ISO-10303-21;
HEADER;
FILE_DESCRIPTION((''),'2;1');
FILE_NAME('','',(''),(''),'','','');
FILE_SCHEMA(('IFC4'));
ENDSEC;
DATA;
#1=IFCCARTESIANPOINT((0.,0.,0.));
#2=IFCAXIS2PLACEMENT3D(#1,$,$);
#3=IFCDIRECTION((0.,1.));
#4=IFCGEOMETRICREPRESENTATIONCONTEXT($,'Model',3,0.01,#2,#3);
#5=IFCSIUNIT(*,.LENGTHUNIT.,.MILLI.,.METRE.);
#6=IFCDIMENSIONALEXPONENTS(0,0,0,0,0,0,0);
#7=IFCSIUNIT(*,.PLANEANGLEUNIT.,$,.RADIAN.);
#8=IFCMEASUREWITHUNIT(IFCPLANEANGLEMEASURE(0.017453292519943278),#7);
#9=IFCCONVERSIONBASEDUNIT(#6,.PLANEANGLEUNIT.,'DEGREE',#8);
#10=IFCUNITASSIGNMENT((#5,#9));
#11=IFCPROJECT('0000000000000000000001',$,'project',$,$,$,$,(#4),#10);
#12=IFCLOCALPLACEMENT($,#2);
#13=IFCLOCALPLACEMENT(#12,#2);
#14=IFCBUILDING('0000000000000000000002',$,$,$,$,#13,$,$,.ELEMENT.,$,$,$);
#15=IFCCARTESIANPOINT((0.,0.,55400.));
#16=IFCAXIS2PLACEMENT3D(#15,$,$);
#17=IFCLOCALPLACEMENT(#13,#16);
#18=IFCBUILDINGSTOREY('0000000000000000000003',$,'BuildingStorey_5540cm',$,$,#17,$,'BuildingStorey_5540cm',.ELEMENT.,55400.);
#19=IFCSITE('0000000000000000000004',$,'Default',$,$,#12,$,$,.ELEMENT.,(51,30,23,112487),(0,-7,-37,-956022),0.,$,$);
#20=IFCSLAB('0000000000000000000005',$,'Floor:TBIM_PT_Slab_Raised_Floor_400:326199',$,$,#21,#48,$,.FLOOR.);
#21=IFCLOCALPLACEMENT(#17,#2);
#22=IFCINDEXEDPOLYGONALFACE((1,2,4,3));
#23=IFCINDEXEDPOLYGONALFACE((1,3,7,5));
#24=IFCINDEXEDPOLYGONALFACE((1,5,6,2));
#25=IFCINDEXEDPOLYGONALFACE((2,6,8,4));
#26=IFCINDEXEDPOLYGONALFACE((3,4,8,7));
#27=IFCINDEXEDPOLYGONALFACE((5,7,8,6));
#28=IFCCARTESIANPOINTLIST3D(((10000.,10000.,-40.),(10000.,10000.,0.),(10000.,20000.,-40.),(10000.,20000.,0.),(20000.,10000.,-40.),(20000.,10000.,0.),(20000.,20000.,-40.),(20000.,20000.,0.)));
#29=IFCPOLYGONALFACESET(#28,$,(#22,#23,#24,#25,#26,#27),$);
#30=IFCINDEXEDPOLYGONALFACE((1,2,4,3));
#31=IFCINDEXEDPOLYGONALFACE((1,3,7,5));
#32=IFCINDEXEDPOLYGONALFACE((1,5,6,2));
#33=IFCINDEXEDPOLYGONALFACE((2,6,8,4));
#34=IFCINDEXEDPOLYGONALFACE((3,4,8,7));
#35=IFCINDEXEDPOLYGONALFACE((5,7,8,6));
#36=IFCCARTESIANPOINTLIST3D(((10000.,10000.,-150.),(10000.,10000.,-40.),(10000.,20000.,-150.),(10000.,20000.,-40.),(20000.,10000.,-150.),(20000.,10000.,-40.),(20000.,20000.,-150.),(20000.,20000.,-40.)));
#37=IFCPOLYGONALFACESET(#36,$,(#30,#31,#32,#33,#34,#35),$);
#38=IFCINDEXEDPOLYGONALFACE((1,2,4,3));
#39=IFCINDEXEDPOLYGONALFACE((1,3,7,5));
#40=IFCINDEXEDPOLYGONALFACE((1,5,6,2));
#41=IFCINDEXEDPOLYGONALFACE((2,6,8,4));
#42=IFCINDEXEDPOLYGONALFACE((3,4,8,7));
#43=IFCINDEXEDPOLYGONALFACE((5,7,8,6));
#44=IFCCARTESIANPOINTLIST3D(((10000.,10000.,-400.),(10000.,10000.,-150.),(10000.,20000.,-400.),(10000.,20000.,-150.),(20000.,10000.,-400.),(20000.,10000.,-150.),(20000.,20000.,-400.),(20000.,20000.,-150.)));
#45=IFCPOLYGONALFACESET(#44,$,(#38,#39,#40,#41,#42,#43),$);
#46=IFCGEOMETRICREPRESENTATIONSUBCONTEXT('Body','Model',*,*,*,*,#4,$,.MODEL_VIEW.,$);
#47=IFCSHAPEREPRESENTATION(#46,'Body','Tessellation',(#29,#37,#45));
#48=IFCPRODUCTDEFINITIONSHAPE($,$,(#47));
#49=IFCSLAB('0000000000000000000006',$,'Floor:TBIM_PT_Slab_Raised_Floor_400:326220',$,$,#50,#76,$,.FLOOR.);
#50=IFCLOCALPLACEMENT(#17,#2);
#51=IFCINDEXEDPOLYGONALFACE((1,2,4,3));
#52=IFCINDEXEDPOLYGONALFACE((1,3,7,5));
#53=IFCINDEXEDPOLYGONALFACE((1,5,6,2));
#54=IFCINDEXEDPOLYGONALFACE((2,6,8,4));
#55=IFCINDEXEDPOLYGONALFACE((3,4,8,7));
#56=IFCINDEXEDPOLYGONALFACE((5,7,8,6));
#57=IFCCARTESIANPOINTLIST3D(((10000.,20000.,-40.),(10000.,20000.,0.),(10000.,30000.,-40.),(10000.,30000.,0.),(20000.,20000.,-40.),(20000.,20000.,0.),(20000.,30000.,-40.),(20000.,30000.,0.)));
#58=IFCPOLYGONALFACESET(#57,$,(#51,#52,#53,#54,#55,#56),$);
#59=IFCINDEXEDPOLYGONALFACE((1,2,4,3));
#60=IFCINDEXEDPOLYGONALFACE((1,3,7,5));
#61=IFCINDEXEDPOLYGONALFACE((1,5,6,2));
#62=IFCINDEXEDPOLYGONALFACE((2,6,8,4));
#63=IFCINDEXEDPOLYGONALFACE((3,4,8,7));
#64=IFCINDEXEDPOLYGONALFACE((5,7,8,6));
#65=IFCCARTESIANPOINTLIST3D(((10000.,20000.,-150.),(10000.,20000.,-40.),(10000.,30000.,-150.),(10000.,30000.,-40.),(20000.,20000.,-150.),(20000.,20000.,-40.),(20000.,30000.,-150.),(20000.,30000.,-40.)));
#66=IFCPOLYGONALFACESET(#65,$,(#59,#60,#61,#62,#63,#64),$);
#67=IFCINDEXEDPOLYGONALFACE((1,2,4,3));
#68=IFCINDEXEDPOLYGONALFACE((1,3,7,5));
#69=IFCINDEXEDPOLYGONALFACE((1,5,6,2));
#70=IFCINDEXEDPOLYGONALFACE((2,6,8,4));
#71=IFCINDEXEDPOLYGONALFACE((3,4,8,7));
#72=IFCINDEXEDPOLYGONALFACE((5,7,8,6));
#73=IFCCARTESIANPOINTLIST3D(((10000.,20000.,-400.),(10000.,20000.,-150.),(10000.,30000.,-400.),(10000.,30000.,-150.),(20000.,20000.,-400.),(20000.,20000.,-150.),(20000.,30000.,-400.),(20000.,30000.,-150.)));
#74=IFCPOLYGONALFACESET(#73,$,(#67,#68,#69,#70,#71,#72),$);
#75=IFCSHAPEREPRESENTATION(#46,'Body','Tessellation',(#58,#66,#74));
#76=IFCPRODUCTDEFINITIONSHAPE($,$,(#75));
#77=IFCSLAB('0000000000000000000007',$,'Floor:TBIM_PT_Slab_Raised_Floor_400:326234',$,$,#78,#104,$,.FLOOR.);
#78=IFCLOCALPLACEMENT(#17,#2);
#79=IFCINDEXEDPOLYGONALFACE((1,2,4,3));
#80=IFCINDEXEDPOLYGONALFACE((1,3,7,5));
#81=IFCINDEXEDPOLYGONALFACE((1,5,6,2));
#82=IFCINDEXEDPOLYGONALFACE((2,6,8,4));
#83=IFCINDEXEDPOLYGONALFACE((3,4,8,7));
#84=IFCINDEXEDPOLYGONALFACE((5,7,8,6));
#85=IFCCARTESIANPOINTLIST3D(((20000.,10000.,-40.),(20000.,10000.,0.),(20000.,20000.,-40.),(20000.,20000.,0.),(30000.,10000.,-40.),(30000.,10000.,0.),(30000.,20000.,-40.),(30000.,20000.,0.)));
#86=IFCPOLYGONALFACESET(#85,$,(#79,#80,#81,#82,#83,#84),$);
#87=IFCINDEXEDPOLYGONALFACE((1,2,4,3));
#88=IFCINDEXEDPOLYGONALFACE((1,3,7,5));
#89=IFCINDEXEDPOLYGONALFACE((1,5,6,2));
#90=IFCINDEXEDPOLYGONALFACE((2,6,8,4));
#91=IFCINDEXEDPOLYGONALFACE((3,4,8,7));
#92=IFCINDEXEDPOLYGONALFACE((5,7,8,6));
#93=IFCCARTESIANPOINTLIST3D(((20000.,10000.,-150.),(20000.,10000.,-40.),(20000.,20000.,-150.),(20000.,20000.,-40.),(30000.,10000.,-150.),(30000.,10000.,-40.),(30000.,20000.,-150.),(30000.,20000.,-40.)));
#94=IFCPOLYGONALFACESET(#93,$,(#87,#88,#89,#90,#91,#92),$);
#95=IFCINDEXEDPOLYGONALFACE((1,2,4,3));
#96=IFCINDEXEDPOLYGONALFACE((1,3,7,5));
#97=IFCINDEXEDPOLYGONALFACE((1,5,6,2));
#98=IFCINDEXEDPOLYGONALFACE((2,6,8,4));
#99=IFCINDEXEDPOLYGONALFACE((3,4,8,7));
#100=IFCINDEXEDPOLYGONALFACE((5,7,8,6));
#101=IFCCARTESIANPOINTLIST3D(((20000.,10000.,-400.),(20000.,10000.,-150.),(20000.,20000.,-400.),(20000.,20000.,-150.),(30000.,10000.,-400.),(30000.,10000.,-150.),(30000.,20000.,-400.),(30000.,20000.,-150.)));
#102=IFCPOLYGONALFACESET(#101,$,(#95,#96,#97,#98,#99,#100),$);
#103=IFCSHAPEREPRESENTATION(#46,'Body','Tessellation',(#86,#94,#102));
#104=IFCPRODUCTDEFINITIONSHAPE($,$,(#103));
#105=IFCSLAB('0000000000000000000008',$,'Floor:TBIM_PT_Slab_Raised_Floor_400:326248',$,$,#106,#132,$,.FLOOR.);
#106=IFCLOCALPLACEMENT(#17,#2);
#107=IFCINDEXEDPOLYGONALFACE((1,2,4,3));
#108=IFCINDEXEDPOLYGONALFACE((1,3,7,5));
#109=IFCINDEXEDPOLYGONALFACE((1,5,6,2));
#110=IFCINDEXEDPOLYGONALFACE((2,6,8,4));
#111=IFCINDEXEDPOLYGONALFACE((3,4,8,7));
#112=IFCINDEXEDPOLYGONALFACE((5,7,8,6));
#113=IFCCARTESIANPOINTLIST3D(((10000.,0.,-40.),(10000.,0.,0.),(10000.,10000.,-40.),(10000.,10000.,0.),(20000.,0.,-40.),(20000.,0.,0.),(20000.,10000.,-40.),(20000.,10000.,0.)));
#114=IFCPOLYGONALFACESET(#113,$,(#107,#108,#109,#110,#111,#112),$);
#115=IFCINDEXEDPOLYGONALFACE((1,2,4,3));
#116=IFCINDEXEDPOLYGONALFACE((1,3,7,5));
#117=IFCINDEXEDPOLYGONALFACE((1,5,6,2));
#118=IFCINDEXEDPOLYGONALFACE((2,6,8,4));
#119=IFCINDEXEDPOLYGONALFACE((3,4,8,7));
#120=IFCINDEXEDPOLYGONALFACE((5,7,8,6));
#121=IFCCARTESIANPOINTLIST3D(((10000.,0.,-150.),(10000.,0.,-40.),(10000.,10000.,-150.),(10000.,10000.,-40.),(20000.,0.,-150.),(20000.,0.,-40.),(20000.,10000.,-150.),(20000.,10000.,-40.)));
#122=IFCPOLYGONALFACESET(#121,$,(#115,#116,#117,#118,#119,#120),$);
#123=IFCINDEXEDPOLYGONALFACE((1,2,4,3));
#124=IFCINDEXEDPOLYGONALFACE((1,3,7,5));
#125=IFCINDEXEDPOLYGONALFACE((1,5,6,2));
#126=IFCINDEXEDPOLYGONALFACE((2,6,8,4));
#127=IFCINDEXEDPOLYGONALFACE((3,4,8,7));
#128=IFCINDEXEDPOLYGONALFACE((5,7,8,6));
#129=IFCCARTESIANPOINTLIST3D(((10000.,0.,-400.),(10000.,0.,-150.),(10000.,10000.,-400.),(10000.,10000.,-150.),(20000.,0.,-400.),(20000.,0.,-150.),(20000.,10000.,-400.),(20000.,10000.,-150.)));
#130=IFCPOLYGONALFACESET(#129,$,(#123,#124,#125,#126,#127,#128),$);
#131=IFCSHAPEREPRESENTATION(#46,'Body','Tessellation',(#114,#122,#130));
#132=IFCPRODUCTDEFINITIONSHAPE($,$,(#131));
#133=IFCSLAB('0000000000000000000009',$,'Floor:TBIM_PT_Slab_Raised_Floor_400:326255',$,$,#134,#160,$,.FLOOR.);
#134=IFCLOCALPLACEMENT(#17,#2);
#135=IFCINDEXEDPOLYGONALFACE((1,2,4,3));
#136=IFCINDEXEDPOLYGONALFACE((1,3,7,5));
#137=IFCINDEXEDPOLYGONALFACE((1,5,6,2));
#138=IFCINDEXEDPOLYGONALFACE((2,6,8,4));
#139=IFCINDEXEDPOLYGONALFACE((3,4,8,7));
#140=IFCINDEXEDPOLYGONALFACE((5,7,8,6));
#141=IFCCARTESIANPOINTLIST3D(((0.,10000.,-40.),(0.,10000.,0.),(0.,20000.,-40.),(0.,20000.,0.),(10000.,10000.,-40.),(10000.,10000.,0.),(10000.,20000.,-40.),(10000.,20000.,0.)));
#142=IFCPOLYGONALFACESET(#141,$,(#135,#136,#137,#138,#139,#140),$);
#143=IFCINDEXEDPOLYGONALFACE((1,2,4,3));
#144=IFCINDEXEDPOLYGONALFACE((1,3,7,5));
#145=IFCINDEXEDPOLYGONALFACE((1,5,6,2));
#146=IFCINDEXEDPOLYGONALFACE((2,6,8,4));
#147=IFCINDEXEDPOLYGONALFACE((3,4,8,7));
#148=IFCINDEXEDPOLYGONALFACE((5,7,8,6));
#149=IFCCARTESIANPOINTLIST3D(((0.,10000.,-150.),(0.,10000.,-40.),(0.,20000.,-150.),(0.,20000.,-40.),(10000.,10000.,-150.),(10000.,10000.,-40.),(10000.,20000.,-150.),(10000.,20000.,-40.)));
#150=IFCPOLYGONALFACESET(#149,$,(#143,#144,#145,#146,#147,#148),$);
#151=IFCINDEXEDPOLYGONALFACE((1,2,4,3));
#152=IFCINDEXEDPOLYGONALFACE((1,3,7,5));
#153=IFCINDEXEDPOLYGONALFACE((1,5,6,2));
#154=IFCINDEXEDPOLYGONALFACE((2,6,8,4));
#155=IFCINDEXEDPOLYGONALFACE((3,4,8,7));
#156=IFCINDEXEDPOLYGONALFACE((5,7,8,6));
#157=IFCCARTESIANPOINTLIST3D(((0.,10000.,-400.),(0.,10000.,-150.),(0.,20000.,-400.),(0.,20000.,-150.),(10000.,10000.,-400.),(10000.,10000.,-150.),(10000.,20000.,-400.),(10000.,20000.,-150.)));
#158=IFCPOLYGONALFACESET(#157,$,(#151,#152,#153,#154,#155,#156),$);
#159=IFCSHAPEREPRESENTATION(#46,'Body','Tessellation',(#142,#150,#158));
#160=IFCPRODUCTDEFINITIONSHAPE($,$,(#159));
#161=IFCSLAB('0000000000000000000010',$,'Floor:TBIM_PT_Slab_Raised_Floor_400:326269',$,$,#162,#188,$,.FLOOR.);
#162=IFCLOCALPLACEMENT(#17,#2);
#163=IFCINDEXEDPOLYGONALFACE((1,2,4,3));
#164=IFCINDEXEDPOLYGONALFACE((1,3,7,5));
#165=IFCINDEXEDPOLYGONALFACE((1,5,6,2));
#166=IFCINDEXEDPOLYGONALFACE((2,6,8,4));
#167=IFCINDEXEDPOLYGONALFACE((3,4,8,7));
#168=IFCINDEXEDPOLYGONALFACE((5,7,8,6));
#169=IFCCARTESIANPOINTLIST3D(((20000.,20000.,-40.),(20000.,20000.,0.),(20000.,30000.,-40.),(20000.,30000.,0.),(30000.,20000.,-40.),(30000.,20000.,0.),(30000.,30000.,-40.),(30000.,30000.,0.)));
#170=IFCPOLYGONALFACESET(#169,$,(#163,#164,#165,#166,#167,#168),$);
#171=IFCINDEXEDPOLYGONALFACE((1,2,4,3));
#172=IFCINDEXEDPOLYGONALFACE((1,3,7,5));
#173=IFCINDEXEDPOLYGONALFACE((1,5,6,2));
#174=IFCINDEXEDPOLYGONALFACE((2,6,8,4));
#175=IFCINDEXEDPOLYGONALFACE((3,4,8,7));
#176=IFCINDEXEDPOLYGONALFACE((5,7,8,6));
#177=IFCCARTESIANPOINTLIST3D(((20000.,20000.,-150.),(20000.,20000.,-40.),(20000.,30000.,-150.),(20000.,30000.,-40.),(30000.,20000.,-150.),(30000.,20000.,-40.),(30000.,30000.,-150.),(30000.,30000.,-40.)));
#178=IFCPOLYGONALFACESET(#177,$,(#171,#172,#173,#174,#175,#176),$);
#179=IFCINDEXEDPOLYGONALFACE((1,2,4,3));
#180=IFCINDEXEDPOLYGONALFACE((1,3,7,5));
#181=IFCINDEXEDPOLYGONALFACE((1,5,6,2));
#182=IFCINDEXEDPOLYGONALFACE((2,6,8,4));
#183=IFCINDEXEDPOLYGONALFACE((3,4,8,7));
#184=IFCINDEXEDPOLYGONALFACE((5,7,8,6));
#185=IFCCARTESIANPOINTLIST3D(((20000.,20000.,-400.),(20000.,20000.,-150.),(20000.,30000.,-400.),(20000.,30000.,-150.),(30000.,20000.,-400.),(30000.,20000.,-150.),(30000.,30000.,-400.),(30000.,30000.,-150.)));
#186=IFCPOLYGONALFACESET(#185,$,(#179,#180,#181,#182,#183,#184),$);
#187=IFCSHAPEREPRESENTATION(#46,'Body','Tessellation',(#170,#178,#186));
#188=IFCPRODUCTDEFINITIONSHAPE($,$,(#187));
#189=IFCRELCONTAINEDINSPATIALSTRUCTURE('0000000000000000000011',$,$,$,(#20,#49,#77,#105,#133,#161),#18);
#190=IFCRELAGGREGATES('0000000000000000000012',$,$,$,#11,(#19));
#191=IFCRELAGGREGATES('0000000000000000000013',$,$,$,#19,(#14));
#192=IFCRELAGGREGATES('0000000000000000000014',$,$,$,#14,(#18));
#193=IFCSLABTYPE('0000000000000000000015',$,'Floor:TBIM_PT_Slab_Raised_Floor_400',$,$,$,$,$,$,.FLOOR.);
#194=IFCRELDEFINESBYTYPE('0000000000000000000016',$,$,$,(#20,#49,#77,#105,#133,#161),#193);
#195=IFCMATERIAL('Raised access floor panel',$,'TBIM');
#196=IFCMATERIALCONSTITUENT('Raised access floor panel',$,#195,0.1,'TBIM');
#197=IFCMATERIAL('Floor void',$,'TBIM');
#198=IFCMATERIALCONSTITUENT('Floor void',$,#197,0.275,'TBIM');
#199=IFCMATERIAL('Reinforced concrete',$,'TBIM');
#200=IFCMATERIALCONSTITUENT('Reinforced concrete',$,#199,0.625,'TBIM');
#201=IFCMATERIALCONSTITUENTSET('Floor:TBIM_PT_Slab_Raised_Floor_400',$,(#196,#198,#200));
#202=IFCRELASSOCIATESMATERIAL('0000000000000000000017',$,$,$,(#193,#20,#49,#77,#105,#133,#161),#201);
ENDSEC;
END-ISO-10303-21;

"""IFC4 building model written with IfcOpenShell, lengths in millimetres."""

from ifc_helpers import new_model, entity, si_unit, converted_unit, direction, frame, origin, place, context, subcontext, project, spatial, indexed_curve, outline, extrude, material, constituent, constituent_set, type_object, element, save


model = new_model("IFC4")

# Units and contexts
model_context = context("Model", 3, precision=0.01, world=origin(), true_north=direction((0.0, 1.0)))
body_context = subcontext(model_context, "Body", "Model", "MODEL_VIEW")
ifc_project = project(units=[si_unit("LENGTHUNIT", "METRE", prefix="MILLI"), converted_unit("PLANEANGLEUNIT", "DEGREE", entity("IfcPlaneAngleMeasure", 0.017453292519943278), si_unit("PLANEANGLEUNIT", "RADIAN"), dimensions=[0, 0, 0, 0, 0, 0, 0])], contexts=[model_context])

# Site, building, storey
site_placement = place(None, origin())
site = spatial("IfcSite", under=ifc_project, at=site_placement, Name="Default", CompositionType="ELEMENT", RefLatitude=(51, 30, 23, 112487), RefLongitude=(0, -7, -37, -956022), RefElevation=0.0)
building_placement = place(site_placement, origin())
building = spatial("IfcBuilding", under=site, at=building_placement, CompositionType="ELEMENT")
storey_placement = place(building_placement, frame((0.0, 0.0, 55400.0)))
storey = spatial("IfcBuildingStorey", under=building, at=storey_placement, Name="BuildingStorey_5540cm", LongName="BuildingStorey_5540cm", CompositionType="ELEMENT", Elevation=55400.0)

# Slabs
ifc_material_1 = material(Name="Raised access floor panel", Category="TBIM")
ifc_constituent_1 = constituent(ifc_material_1, Name="Raised access floor panel", Category="TBIM", fraction=0.1)
ifc_material_2 = material(Name="Floor void", Category="TBIM")
ifc_constituent_2 = constituent(ifc_material_2, Name="Floor void", Category="TBIM", fraction=0.275)
ifc_material_3 = material(Name="Reinforced concrete", Category="TBIM")
ifc_constituent_3 = constituent(ifc_material_3, Name="Reinforced concrete", Category="TBIM", fraction=0.625)
ifc_constituent_set_1 = constituent_set(constituents=[ifc_constituent_1, ifc_constituent_2, ifc_constituent_3], Name="Floor:TBIM_PT_Slab_Raised_Floor_400")
slab_type = type_object("IfcSlabType", Name="Floor:TBIM_PT_Slab_Raised_Floor_400", PredefinedType="FLOOR", material=ifc_constituent_set_1)
slab_1_placement = place(storey_placement, origin())
element("IfcSlab", 1, at=slab_1_placement, inside=storey, type_object=slab_type, material=ifc_constituent_set_1, Name="Floor:TBIM_PT_Slab_Raised_Floor_400:326199", PredefinedType="FLOOR", context=body_context, shape_type="SweptSolid", body=[
    extrude(outline(indexed_curve([(-5000.0, -5000.0), (5000.0, -5000.0), (5000.0, 5000.0), (-5000.0, 5000.0), (-5000.0, -5000.0)], self_intersect=False)), frame((15000.0, 15000.0, -40.0), z_axis=(0.0, 0.0, 1.0), x_axis=(-1.0, 0.0, 0.0)), (0.0, 0.0, 1.0), 40.0),
    extrude(outline(indexed_curve([(-5000.0, -5000.0), (5000.0, -5000.0), (5000.0, 5000.0), (-5000.0, 5000.0), (-5000.0, -5000.0)], self_intersect=False)), frame((15000.0, 15000.0, -150.0), z_axis=(0.0, 0.0, 1.0), x_axis=(-1.0, 0.0, 0.0)), (0.0, 0.0, 1.0), 110.0),
    extrude(outline(indexed_curve([(-5000.0, -5000.0), (5000.0, -5000.0), (5000.0, 5000.0), (-5000.0, 5000.0), (-5000.0, -5000.0)], self_intersect=False)), frame((15000.0, 15000.0, -400.0), z_axis=(0.0, 0.0, 1.0), x_axis=(-1.0, 0.0, 0.0)), (0.0, 0.0, 1.0), 250.0),
])
slab_2_placement = place(storey_placement, origin())
element("IfcSlab", 2, at=slab_2_placement, inside=storey, type_object=slab_type, material=ifc_constituent_set_1, Name="Floor:TBIM_PT_Slab_Raised_Floor_400:326220", PredefinedType="FLOOR", context=body_context, shape_type="SweptSolid", body=[
    extrude(outline(indexed_curve([(-5000.0, -5000.0), (5000.0, -5000.0), (5000.0, 5000.0), (-5000.0, 5000.0), (-5000.0, -5000.0)], self_intersect=False)), frame((15000.0, 25000.0, -40.0), z_axis=(0.0, 0.0, 1.0), x_axis=(-1.0, 0.0, 0.0)), (0.0, 0.0, 1.0), 40.0),
    extrude(outline(indexed_curve([(-5000.0, -5000.0), (5000.0, -5000.0), (5000.0, 5000.0), (-5000.0, 5000.0), (-5000.0, -5000.0)], self_intersect=False)), frame((15000.0, 25000.0, -150.0), z_axis=(0.0, 0.0, 1.0), x_axis=(-1.0, 0.0, 0.0)), (0.0, 0.0, 1.0), 110.0),
    extrude(outline(indexed_curve([(-5000.0, -5000.0), (5000.0, -5000.0), (5000.0, 5000.0), (-5000.0, 5000.0), (-5000.0, -5000.0)], self_intersect=False)), frame((15000.0, 25000.0, -400.0), z_axis=(0.0, 0.0, 1.0), x_axis=(-1.0, 0.0, 0.0)), (0.0, 0.0, 1.0), 250.0),
])
slab_3_placement = place(storey_placement, origin())
element("IfcSlab", 3, at=slab_3_placement, inside=storey, type_object=slab_type, material=ifc_constituent_set_1, Name="Floor:TBIM_PT_Slab_Raised_Floor_400:326234", PredefinedType="FLOOR", context=body_context, shape_type="SweptSolid", body=[
    extrude(outline(indexed_curve([(-5000.0, -5000.0), (5000.0, -5000.0), (5000.0, 5000.0), (-5000.0, 5000.0), (-5000.0, -5000.0)], self_intersect=False)), frame((25000.0, 15000.0, -40.0), z_axis=(0.0, 0.0, 1.0), x_axis=(-1.0, 0.0, 0.0)), (0.0, 0.0, 1.0), 40.0),
    extrude(outline(indexed_curve([(-5000.0, -5000.0), (5000.0, -5000.0), (5000.0, 5000.0), (-5000.0, 5000.0), (-5000.0, -5000.0)], self_intersect=False)), frame((25000.0, 15000.0, -150.0), z_axis=(0.0, 0.0, 1.0), x_axis=(-1.0, 0.0, 0.0)), (0.0, 0.0, 1.0), 110.0),
    extrude(outline(indexed_curve([(-5000.0, -5000.0), (5000.0, -5000.0), (5000.0, 5000.0), (-5000.0, 5000.0), (-5000.0, -5000.0)], self_intersect=False)), frame((25000.0, 15000.0, -400.0), z_axis=(0.0, 0.0, 1.0), x_axis=(-1.0, 0.0, 0.0)), (0.0, 0.0, 1.0), 250.0),
])
slab_4_placement = place(storey_placement, origin())
element("IfcSlab", 4, at=slab_4_placement, inside=storey, type_object=slab_type, material=ifc_constituent_set_1, Name="Floor:TBIM_PT_Slab_Raised_Floor_400:326248", PredefinedType="FLOOR", context=body_context, shape_type="SweptSolid", body=[
    extrude(outline(indexed_curve([(-5000.0, -5000.0), (5000.0, -5000.0), (5000.0, 5000.0), (-5000.0, 5000.0), (-5000.0, -5000.0)], self_intersect=False)), frame((15000.0, 5000.0, -40.0), z_axis=(0.0, 0.0, 1.0), x_axis=(0.0, 1.0, 0.0)), (0.0, 0.0, 1.0), 40.0),
    extrude(outline(indexed_curve([(-5000.0, -5000.0), (5000.0, -5000.0), (5000.0, 5000.0), (-5000.0, 5000.0), (-5000.0, -5000.0)], self_intersect=False)), frame((15000.0, 5000.0, -150.0), z_axis=(0.0, 0.0, 1.0), x_axis=(0.0, 1.0, 0.0)), (0.0, 0.0, 1.0), 110.0),
    extrude(outline(indexed_curve([(-5000.0, -5000.0), (5000.0, -5000.0), (5000.0, 5000.0), (-5000.0, 5000.0), (-5000.0, -5000.0)], self_intersect=False)), frame((15000.0, 5000.0, -400.0), z_axis=(0.0, 0.0, 1.0), x_axis=(0.0, 1.0, 0.0)), (0.0, 0.0, 1.0), 250.0),
])
slab_5_placement = place(storey_placement, origin())
element("IfcSlab", 5, at=slab_5_placement, inside=storey, type_object=slab_type, material=ifc_constituent_set_1, Name="Floor:TBIM_PT_Slab_Raised_Floor_400:326255", PredefinedType="FLOOR", context=body_context, shape_type="SweptSolid", body=[
    extrude(outline(indexed_curve([(-5000.0, -5000.0), (5000.0, -5000.0), (5000.0, 5000.0), (-5000.0, 5000.0), (-5000.0, -5000.0)], self_intersect=False)), frame((5000.0, 15000.0, -40.0), z_axis=(0.0, 0.0, 1.0), x_axis=(0.0, 1.0, 0.0)), (0.0, 0.0, 1.0), 40.0),
    extrude(outline(indexed_curve([(-5000.0, -5000.0), (5000.0, -5000.0), (5000.0, 5000.0), (-5000.0, 5000.0), (-5000.0, -5000.0)], self_intersect=False)), frame((5000.0, 15000.0, -150.0), z_axis=(0.0, 0.0, 1.0), x_axis=(0.0, 1.0, 0.0)), (0.0, 0.0, 1.0), 110.0),
    extrude(outline(indexed_curve([(-5000.0, -5000.0), (5000.0, -5000.0), (5000.0, 5000.0), (-5000.0, 5000.0), (-5000.0, -5000.0)], self_intersect=False)), frame((5000.0, 15000.0, -400.0), z_axis=(0.0, 0.0, 1.0), x_axis=(0.0, 1.0, 0.0)), (0.0, 0.0, 1.0), 250.0),
])
slab_6_placement = place(storey_placement, origin())
element("IfcSlab", 6, at=slab_6_placement, inside=storey, type_object=slab_type, material=ifc_constituent_set_1, Name="Floor:TBIM_PT_Slab_Raised_Floor_400:326269", PredefinedType="FLOOR", context=body_context, shape_type="SweptSolid", body=[
    extrude(outline(indexed_curve([(-5000.0, -5000.0), (5000.0, -5000.0), (5000.0, 5000.0), (-5000.0, 5000.0), (-5000.0, -5000.0)], self_intersect=False)), frame((25000.0, 25000.0, -40.0), z_axis=(0.0, 0.0, 1.0), x_axis=(-1.0, 0.0, 0.0)), (0.0, 0.0, 1.0), 40.0),
    extrude(outline(indexed_curve([(-5000.0, -5000.0), (5000.0, -5000.0), (5000.0, 5000.0), (-5000.0, 5000.0), (-5000.0, -5000.0)], self_intersect=False)), frame((25000.0, 25000.0, -150.0), z_axis=(0.0, 0.0, 1.0), x_axis=(-1.0, 0.0, 0.0)), (0.0, 0.0, 1.0), 110.0),
    extrude(outline(indexed_curve([(-5000.0, -5000.0), (5000.0, -5000.0), (5000.0, 5000.0), (-5000.0, 5000.0), (-5000.0, -5000.0)], self_intersect=False)), frame((25000.0, 25000.0, -400.0), z_axis=(0.0, 0.0, 1.0), x_axis=(-1.0, 0.0, 0.0)), (0.0, 0.0, 1.0), 250.0),
])

save(model, "model.ifc")
